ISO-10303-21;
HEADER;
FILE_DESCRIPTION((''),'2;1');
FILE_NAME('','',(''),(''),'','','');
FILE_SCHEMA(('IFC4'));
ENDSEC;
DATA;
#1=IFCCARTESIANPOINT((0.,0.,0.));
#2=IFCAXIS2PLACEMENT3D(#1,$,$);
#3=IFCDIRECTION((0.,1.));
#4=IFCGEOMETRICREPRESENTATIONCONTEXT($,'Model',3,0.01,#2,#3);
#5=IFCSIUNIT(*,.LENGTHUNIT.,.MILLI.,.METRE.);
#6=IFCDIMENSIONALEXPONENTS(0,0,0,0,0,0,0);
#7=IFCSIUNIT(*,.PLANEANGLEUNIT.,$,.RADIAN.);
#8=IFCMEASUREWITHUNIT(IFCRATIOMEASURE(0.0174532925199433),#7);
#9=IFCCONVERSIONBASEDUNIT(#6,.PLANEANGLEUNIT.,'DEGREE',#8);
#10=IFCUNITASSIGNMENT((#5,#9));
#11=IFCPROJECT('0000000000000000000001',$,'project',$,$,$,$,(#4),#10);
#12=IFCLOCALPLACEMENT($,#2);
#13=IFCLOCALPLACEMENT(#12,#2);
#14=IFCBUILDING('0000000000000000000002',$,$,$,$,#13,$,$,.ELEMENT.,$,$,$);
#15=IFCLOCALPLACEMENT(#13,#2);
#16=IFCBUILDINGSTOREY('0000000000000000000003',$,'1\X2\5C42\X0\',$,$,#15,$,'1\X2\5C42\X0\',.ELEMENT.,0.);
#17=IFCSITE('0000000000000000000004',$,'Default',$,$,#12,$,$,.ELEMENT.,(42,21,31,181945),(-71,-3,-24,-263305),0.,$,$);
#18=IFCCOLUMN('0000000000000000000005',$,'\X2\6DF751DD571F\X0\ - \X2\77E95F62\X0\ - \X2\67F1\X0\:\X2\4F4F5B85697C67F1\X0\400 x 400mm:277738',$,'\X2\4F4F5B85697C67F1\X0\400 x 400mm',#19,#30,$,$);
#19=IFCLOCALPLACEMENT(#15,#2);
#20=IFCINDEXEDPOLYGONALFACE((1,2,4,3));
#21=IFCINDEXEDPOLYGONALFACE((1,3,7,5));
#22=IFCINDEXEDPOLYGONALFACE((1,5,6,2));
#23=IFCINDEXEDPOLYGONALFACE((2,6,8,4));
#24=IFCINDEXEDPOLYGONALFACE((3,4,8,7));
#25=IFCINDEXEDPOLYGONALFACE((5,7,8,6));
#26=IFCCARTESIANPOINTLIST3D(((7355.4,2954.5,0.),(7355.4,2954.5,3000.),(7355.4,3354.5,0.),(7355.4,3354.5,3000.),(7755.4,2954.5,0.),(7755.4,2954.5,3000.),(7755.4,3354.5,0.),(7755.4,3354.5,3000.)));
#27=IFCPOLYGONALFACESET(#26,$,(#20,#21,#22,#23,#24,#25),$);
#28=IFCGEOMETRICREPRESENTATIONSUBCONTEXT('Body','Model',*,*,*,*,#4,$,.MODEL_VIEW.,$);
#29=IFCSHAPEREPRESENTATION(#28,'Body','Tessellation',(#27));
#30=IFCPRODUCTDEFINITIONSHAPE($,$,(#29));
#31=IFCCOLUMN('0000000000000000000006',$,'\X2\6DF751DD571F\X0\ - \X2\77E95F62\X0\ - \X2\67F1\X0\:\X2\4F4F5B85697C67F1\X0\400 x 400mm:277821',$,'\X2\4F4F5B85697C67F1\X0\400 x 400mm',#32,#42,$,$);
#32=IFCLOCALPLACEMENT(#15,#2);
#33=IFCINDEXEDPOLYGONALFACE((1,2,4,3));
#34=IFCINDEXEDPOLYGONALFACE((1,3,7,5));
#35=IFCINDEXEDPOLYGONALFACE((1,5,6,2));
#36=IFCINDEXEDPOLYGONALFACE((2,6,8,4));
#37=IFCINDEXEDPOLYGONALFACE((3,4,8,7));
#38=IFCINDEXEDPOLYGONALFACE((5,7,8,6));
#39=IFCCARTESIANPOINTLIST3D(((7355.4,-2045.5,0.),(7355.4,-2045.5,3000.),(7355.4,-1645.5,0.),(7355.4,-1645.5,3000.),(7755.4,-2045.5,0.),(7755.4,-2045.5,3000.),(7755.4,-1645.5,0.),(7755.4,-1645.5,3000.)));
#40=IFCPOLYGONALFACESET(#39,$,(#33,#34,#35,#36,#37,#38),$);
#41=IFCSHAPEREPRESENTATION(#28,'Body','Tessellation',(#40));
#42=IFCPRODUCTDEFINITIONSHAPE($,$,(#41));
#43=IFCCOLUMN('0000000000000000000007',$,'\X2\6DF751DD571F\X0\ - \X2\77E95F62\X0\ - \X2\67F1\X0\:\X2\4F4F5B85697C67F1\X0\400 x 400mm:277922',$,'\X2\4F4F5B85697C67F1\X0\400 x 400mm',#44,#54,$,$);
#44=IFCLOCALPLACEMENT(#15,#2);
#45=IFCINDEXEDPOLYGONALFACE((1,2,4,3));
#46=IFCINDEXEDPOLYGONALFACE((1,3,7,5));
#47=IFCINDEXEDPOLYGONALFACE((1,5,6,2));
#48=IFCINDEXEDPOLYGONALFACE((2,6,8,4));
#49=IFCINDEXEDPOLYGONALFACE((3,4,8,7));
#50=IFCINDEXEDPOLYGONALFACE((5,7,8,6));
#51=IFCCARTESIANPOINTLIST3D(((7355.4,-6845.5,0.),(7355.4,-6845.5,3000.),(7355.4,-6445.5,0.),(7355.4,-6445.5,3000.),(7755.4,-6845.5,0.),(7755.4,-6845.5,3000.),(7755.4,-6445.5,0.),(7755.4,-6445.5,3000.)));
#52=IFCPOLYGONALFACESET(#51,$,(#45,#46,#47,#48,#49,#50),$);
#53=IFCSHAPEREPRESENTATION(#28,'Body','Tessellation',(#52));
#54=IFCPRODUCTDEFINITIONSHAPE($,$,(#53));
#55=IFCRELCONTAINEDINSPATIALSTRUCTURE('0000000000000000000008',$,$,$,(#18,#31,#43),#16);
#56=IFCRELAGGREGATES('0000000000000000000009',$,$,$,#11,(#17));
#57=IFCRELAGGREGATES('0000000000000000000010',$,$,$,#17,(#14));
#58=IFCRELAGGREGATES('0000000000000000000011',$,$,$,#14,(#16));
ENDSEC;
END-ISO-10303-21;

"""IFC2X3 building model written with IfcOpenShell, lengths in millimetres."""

from ifc_helpers import new_model, entity, si_unit, converted_unit, direction, frame, origin, origin_2d_with_axis, place, context, subcontext, project, spatial, rectangle, extrude, source, transform, mapped, element, save


model = new_model("IFC2X3")

# Units and contexts
model_context = context("Model", 3, precision=0.01, world=origin(), true_north=direction((0.0, 1.0)))
body_context = subcontext(model_context, "Body", "Model", "MODEL_VIEW")
ifc_project = project(units=[si_unit("LENGTHUNIT", "METRE", prefix="MILLI"), converted_unit("PLANEANGLEUNIT", "DEGREE", entity("IfcRatioMeasure", 0.0174532925199433), si_unit("PLANEANGLEUNIT", "RADIAN"), dimensions=[0, 0, 0, 0, 0, 0, 0])], contexts=[model_context])

# Site, building, storey
site_placement = place(None, origin())
site = spatial("IfcSite", under=ifc_project, at=site_placement, Name="Default", CompositionType="ELEMENT", RefLatitude=(42, 21, 31, 181945), RefLongitude=(-71, -3, -24, -263305), RefElevation=0.0)
building_placement = place(site_placement, origin())
building = spatial("IfcBuilding", under=site, at=building_placement, CompositionType="ELEMENT")
storey_placement = place(building_placement, origin())
storey = spatial("IfcBuildingStorey", under=building, at=storey_placement, Name="1层", LongName="1层", CompositionType="ELEMENT", Elevation=0.0)

# Columns
shared_shape_1 = source(origin(), body_context, "Body", "SweptSolid", [
    extrude(rectangle(XDim=400.0, YDim=400.0, at=origin_2d_with_axis()), frame((7555.4, 3154.5, 0.0), z_axis=(0.0, 0.0, 1.0), x_axis=(0.0, -1.0, 0.0)), (0.0, 0.0, 1.0), 3000.0),
])
column_1_placement = place(storey_placement, origin())
element("IfcColumn", 1, at=column_1_placement, inside=storey, Name="混凝土 - 矩形 - 柱:住宅楼柱400 x 400mm:277738", ObjectType="住宅楼柱400 x 400mm", context=body_context, shape_type="MappedRepresentation", body=[
    mapped(shared_shape_1, transform((0.0, 0.0, 0.0), scale=1.0)),
])
shared_shape_2 = source(origin(), body_context, "Body", "SweptSolid", [
    extrude(rectangle(XDim=400.0, YDim=400.0, at=origin_2d_with_axis()), frame((7555.4, -1845.5, 0.0), z_axis=(0.0, 0.0, 1.0), x_axis=(0.0, -1.0, 0.0)), (0.0, 0.0, 1.0), 3000.0),
])
column_2_placement = place(storey_placement, origin())
element("IfcColumn", 2, at=column_2_placement, inside=storey, Name="混凝土 - 矩形 - 柱:住宅楼柱400 x 400mm:277821", ObjectType="住宅楼柱400 x 400mm", context=body_context, shape_type="MappedRepresentation", body=[
    mapped(shared_shape_2, transform((0.0, 0.0, 0.0), scale=1.0)),
])
shared_shape_3 = source(origin(), body_context, "Body", "SweptSolid", [
    extrude(rectangle(XDim=400.0, YDim=400.0, at=origin_2d_with_axis()), frame((7555.4, -6645.5, 0.0), z_axis=(0.0, 0.0, 1.0), x_axis=(0.0, -1.0, 0.0)), (0.0, 0.0, 1.0), 3000.0),
])
column_3_placement = place(storey_placement, origin())
element("IfcColumn", 3, at=column_3_placement, inside=storey, Name="混凝土 - 矩形 - 柱:住宅楼柱400 x 400mm:277922", ObjectType="住宅楼柱400 x 400mm", context=body_context, shape_type="MappedRepresentation", body=[
    mapped(shared_shape_3, transform((0.0, 0.0, 0.0), scale=1.0)),
])

save(model, "model.ifc")
